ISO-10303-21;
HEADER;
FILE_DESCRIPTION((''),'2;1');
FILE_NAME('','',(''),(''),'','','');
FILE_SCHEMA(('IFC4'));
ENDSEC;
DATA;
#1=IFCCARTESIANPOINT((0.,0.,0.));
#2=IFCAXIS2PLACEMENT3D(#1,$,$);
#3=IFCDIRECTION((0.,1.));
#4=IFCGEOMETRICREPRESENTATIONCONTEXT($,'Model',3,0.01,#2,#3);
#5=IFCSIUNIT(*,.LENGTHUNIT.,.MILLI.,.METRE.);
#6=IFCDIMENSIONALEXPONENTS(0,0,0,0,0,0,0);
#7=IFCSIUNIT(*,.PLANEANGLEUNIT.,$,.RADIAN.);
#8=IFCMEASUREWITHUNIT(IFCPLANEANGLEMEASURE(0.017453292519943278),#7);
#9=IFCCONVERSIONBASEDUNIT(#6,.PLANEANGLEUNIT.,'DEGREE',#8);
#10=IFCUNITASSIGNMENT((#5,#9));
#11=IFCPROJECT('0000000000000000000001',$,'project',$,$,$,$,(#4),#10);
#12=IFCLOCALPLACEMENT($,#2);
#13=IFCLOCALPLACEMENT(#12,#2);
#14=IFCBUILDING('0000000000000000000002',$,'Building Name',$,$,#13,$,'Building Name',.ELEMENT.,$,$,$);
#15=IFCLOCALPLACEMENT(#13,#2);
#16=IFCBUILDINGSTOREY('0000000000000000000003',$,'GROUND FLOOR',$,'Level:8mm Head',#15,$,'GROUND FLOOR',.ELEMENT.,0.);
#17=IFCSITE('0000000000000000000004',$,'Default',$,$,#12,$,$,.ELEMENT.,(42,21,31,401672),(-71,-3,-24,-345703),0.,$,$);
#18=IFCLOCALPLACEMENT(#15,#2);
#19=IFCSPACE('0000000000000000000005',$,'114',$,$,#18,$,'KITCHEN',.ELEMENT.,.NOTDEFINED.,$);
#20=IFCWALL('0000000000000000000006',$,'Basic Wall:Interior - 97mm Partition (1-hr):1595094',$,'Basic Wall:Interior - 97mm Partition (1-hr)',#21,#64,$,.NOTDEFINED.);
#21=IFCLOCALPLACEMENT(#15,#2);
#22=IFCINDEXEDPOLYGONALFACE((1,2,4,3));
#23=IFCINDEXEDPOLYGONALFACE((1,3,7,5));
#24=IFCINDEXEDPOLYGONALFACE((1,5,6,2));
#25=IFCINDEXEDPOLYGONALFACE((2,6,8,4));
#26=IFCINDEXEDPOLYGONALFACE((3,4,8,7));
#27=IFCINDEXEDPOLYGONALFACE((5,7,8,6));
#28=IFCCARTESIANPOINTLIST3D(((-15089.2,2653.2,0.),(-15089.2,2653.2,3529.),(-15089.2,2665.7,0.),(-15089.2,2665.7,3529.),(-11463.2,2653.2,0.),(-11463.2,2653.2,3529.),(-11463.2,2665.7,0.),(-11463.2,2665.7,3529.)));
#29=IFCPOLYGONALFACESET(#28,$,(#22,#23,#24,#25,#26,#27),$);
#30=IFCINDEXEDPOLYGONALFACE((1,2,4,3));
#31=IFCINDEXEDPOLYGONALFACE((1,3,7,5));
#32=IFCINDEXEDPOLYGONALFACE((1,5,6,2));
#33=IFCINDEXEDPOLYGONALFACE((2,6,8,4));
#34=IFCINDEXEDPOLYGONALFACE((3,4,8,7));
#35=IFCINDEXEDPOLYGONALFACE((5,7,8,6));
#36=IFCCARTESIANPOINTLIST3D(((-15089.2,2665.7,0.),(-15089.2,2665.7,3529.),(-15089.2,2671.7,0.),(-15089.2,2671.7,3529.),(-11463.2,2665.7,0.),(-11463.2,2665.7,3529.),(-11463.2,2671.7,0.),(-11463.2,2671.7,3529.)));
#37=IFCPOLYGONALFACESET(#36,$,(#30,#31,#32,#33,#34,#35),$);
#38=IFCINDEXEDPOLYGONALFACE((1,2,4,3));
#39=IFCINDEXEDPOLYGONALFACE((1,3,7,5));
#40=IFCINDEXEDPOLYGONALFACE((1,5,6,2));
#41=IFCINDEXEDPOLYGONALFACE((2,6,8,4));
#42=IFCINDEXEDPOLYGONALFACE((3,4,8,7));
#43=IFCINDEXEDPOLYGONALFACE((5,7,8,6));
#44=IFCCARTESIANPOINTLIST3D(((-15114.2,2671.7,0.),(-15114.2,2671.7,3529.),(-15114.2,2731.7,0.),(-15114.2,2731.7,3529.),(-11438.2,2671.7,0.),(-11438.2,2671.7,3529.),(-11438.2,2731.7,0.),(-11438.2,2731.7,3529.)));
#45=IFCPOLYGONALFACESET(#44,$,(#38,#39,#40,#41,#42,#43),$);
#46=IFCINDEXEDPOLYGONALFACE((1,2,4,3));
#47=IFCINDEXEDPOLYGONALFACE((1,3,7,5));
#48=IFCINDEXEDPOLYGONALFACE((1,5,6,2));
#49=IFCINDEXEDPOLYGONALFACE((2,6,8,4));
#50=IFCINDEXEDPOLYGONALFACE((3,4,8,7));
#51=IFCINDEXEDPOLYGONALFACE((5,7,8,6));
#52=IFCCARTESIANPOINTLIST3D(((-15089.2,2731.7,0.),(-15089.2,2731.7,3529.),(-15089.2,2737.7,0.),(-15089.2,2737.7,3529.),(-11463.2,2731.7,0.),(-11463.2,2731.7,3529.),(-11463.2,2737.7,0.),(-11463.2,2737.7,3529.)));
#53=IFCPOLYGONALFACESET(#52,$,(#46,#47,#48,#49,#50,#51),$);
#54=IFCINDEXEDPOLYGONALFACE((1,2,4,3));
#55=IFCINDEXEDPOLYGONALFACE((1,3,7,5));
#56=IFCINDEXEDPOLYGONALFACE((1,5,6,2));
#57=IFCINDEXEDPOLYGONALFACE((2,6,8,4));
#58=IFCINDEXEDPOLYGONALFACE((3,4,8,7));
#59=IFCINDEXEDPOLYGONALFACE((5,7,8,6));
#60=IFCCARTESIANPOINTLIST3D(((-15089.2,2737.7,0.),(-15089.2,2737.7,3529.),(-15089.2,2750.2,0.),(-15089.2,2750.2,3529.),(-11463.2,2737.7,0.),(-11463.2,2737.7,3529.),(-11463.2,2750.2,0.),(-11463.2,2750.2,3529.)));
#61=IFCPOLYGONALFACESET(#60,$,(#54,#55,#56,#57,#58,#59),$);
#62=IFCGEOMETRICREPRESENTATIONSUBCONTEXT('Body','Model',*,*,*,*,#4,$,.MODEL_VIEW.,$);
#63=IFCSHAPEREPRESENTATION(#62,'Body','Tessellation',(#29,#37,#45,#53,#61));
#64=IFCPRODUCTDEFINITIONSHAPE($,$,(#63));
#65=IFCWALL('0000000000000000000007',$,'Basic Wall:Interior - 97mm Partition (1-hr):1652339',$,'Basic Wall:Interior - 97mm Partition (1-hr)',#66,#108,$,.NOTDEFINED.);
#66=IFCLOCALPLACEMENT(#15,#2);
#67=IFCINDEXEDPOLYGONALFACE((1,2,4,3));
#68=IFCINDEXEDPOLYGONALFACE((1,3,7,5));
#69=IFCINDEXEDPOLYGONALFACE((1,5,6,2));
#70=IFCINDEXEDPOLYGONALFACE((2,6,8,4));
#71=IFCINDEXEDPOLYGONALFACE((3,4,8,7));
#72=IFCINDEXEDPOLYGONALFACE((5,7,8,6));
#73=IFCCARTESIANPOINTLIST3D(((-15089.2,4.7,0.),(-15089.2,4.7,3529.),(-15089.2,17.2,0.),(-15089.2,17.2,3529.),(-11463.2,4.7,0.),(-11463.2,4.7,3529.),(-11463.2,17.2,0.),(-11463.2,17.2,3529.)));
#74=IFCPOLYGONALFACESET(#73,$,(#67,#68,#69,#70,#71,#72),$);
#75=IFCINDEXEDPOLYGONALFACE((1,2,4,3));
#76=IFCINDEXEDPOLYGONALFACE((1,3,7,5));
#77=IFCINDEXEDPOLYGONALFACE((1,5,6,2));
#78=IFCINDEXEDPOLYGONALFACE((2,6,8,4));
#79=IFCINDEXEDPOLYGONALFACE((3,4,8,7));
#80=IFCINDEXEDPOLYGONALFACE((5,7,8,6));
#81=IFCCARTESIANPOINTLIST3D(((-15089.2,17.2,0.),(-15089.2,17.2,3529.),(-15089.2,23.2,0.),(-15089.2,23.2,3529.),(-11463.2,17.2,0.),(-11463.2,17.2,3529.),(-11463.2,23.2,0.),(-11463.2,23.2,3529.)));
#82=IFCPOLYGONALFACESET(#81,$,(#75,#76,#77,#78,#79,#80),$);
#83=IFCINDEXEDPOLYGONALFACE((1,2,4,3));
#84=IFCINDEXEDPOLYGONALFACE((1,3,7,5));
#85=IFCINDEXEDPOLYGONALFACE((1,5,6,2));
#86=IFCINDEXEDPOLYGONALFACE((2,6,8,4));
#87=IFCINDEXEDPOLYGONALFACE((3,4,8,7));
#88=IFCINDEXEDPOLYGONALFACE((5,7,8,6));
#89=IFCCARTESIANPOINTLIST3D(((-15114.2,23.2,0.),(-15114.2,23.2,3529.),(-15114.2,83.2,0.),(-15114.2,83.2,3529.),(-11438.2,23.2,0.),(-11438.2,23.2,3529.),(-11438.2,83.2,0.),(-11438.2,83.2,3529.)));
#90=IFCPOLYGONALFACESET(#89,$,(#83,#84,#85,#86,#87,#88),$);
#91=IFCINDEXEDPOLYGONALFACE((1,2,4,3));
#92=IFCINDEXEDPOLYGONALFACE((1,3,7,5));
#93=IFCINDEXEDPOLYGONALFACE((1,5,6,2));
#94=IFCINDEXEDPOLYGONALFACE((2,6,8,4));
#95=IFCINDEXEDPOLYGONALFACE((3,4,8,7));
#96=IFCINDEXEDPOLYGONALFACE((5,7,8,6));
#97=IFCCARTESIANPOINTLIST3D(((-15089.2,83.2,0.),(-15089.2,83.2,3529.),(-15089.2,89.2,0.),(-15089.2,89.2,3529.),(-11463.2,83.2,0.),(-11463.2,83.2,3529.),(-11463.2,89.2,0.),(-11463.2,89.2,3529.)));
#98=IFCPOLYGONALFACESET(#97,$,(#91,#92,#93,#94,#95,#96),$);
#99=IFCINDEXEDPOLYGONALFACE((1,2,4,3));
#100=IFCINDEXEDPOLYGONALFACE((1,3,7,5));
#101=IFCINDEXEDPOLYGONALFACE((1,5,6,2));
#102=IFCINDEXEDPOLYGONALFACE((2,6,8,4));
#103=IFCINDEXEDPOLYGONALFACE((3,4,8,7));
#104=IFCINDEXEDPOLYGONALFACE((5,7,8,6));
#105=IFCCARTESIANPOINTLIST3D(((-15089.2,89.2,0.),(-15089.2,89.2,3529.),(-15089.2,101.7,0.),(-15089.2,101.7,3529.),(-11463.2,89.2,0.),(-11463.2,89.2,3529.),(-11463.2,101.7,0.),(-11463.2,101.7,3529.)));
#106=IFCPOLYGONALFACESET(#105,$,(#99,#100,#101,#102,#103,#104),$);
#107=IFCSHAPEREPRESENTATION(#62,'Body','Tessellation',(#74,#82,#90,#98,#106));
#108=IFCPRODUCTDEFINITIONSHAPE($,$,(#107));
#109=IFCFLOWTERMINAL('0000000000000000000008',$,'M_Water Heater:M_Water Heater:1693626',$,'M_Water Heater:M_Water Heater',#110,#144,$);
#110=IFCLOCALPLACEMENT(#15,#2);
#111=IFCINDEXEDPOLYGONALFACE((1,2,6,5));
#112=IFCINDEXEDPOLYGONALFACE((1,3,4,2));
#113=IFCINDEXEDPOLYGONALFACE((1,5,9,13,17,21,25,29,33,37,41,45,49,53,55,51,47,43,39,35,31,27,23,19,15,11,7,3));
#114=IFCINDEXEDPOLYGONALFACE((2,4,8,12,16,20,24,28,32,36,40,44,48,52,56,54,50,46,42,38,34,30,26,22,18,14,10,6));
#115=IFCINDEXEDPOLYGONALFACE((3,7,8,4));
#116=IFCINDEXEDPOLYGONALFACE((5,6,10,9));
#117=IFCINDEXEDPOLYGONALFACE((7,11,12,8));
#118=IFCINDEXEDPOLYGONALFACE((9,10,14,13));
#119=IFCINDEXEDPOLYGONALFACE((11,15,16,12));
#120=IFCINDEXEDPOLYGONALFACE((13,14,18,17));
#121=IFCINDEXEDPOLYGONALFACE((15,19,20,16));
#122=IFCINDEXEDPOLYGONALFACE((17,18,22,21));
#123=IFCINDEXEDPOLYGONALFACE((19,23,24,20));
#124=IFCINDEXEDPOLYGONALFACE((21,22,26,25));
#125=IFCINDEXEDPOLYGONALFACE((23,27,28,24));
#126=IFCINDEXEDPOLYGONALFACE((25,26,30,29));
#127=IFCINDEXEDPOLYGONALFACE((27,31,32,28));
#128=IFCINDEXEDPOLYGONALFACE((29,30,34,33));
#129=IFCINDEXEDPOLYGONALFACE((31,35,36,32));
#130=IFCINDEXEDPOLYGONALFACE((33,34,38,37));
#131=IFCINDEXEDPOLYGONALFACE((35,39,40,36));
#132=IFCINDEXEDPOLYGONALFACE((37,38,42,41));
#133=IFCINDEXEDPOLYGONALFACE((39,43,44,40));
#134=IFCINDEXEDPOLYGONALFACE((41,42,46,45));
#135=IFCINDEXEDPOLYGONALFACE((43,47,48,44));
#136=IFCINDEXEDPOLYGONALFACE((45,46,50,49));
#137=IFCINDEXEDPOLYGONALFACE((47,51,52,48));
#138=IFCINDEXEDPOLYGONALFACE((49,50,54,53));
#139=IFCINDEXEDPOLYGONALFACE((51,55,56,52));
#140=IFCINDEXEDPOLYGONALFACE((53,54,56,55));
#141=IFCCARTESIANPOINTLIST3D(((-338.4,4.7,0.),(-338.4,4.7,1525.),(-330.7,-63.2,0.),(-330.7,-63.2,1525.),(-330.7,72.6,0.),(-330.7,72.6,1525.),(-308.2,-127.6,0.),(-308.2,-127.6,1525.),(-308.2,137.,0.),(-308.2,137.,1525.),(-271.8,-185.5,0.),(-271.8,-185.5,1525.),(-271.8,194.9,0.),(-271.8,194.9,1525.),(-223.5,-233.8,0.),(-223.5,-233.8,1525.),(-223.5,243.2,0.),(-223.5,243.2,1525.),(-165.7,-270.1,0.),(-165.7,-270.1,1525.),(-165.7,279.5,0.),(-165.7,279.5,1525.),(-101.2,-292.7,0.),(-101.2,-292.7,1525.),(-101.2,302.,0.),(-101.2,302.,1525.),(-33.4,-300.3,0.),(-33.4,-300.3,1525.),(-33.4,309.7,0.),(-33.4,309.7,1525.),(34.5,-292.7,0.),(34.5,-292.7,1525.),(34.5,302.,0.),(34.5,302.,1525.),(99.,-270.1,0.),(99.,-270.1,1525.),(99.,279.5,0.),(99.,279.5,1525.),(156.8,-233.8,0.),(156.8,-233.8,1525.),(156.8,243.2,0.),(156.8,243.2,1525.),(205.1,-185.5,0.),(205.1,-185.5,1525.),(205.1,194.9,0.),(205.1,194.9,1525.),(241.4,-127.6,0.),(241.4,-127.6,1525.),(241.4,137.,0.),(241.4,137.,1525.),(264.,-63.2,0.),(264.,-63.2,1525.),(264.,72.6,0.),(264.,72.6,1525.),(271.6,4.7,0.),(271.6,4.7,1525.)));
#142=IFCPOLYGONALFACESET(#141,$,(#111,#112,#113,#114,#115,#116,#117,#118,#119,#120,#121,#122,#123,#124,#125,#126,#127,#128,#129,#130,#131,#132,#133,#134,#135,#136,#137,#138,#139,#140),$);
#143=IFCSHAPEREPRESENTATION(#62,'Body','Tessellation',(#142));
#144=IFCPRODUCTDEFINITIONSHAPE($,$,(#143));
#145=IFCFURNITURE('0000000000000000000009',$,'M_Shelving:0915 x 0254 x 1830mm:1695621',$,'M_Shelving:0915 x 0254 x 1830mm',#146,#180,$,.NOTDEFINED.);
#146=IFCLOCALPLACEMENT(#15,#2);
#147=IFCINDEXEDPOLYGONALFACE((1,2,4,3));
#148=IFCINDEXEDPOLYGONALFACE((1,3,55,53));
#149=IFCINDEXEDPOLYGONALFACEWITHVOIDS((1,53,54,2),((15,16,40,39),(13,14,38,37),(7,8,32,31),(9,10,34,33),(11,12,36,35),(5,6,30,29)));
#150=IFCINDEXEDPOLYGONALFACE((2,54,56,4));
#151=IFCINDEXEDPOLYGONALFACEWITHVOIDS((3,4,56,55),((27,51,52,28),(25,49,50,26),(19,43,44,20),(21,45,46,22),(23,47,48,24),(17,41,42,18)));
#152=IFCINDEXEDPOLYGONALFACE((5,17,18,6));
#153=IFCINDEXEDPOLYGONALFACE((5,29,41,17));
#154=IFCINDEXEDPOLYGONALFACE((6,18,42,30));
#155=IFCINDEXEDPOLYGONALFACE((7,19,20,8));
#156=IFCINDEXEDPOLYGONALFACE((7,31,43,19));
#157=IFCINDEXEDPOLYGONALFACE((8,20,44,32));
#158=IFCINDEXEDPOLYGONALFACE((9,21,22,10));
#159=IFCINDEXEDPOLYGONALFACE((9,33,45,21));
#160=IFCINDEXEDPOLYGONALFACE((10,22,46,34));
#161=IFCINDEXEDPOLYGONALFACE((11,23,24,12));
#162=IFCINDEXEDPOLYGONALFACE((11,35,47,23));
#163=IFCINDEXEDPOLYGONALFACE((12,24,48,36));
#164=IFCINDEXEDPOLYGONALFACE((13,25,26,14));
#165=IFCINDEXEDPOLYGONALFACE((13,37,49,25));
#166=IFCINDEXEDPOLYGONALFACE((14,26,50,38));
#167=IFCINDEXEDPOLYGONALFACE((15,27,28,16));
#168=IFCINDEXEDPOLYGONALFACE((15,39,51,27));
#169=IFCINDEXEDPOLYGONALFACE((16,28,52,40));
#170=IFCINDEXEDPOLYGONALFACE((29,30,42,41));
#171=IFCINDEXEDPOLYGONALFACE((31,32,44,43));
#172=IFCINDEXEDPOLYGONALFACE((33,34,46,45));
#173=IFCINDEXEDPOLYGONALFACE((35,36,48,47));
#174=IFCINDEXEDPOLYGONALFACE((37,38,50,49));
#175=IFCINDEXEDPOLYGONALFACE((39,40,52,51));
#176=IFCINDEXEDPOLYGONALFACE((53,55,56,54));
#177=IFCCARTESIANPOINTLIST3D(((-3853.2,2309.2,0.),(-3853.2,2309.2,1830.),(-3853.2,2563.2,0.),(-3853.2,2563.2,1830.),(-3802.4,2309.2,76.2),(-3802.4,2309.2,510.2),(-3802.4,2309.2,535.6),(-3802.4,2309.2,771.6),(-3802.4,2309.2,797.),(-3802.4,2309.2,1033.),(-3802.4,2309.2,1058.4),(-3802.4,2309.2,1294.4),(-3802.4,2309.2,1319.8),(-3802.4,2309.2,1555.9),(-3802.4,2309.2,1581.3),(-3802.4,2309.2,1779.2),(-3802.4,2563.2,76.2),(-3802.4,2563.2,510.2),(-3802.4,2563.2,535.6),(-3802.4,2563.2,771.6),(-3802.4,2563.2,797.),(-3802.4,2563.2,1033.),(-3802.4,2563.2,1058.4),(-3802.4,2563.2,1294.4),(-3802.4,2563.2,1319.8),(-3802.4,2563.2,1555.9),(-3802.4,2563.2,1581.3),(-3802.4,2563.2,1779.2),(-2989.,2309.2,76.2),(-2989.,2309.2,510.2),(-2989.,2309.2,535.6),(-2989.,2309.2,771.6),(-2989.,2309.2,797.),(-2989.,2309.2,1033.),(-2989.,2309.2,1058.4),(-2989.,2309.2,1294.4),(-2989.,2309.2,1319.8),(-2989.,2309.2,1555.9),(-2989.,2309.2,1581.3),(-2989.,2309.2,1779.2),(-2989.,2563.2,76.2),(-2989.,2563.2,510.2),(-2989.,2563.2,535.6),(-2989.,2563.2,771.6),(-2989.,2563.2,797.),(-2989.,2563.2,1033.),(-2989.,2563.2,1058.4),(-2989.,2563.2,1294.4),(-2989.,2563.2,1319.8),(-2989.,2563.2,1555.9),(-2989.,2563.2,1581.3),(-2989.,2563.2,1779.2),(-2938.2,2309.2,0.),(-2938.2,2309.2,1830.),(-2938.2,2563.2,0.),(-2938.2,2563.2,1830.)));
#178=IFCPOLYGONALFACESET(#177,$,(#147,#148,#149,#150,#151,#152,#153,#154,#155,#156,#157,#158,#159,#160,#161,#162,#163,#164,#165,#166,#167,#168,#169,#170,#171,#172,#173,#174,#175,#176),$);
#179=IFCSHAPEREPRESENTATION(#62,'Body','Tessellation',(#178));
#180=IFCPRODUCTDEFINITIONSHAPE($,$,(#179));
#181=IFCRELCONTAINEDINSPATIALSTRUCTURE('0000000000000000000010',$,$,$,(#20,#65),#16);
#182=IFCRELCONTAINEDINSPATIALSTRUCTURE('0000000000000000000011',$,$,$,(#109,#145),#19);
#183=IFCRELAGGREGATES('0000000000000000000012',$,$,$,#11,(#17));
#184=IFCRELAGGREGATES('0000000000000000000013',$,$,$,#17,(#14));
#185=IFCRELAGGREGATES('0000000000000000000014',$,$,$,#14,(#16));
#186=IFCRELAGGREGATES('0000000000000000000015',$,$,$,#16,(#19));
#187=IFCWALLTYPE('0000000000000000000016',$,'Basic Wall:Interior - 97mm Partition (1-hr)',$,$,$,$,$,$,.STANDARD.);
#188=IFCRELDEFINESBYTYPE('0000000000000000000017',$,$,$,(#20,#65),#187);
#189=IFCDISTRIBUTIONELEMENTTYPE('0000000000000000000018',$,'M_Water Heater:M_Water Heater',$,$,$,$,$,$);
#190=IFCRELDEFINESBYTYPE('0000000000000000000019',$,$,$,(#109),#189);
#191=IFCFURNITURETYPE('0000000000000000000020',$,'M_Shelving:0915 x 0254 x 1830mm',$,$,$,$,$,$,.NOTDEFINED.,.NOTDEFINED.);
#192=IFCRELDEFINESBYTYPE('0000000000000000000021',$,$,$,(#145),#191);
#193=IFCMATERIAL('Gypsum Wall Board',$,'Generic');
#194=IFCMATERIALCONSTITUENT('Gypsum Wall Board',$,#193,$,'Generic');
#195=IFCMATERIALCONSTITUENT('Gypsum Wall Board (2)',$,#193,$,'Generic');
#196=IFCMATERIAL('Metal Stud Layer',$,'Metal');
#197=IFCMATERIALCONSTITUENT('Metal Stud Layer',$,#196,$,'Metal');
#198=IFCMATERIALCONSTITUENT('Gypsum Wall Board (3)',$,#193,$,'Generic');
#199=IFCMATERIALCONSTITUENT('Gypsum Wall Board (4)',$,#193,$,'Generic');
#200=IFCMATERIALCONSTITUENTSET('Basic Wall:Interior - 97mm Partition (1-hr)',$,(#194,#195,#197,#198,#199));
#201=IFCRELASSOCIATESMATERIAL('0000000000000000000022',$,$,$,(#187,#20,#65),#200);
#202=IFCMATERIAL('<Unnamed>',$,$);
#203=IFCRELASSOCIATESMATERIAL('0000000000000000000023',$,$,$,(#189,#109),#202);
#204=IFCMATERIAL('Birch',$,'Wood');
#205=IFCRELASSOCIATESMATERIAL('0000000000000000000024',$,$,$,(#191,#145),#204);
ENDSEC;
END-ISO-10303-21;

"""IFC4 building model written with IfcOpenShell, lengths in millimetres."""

from ifc_helpers import new_model, entity, si_unit, converted_unit, direction, frame, origin, place, context, subcontext, project, spatial, arc, indexed_curve, outline, extrude, source, transform, mapped, material, constituent, constituent_set, type_object, type_shapes, element, save


model = new_model("IFC4")

# Units and contexts
model_context = context("Model", 3, precision=0.01, world=origin(), true_north=direction((0.0, 1.0)))
body_context = subcontext(model_context, "Body", "Model", "MODEL_VIEW")
ifc_project = project(units=[si_unit("LENGTHUNIT", "METRE", prefix="MILLI"), converted_unit("PLANEANGLEUNIT", "DEGREE", entity("IfcPlaneAngleMeasure", 0.017453292519943278), si_unit("PLANEANGLEUNIT", "RADIAN"), dimensions=[0, 0, 0, 0, 0, 0, 0])], contexts=[model_context])

# Site, building, storey
site_placement = place(None, origin())
site = spatial("IfcSite", under=ifc_project, at=site_placement, Name="Default", CompositionType="ELEMENT", RefLatitude=(42, 21, 31, 401672), RefLongitude=(-71, -3, -24, -345703), RefElevation=0.0)
building_placement = place(site_placement, origin())
building = spatial("IfcBuilding", under=site, at=building_placement, Name="Building Name", LongName="Building Name", CompositionType="ELEMENT")
storey_placement = place(building_placement, origin())
storey = spatial("IfcBuildingStorey", under=building, at=storey_placement, Name="GROUND FLOOR", ObjectType="Level:8mm Head", LongName="GROUND FLOOR", CompositionType="ELEMENT", Elevation=0.0)

# Walls
ifc_material_1 = material(Name="Gypsum Wall Board", Category="Generic")
ifc_constituent_1 = constituent(ifc_material_1, Name="Gypsum Wall Board", Category="Generic")
ifc_constituent_2 = constituent(ifc_material_1, Name="Gypsum Wall Board (2)", Category="Generic")
ifc_material_2 = material(Name="Metal Stud Layer", Category="Metal")
ifc_constituent_3 = constituent(ifc_material_2, Name="Metal Stud Layer", Category="Metal")
ifc_constituent_4 = constituent(ifc_material_1, Name="Gypsum Wall Board (3)", Category="Generic")
ifc_constituent_5 = constituent(ifc_material_1, Name="Gypsum Wall Board (4)", Category="Generic")
ifc_constituent_set_1 = constituent_set(constituents=[ifc_constituent_1, ifc_constituent_2, ifc_constituent_3, ifc_constituent_4, ifc_constituent_5], Name="Basic Wall:Interior - 97mm Partition (1-hr)")
wall_type_1 = type_object("IfcWallType", Name="Basic Wall:Interior - 97mm Partition (1-hr)", PredefinedType="STANDARD", material=ifc_constituent_set_1)
wall_1_placement = place(storey_placement, frame((-15089.2, 2701.7, 0.0)))
element("IfcWall", 1, at=wall_1_placement, inside=storey, type_object=wall_type_1, material=ifc_constituent_set_1, Name="Basic Wall:Interior - 97mm Partition (1-hr):1595094", ObjectType="Basic Wall:Interior - 97mm Partition (1-hr)", PredefinedType="NOTDEFINED", context=body_context, shape_type="SweptSolid", body=[
    extrude(outline(indexed_curve([(-6.3, -1813.0), (6.2, -1813.0), (6.3, 1813.0), (-6.2, 1813.0), (-6.3, -1813.0)], self_intersect=False)), frame((1813.0, -42.3, 0.0), z_axis=(0.0, 0.0, 1.0), x_axis=(0.0, 1.0, 0.0)), (0.0, 0.0, 1.0), 3529.0),
    extrude(outline(indexed_curve([(-1813.0, -3.0), (1813.0, -3.0), (1813.0, 3.0), (-1813.0, 3.0), (-1813.0, -3.0)], self_intersect=False)), frame((1813.0, -33.0, 0.0)), (0.0, 0.0, 1.0), 3529.0),
    extrude(outline(indexed_curve([(-1838.0, -30.0), (1838.0, -30.0), (1838.0, 30.0), (-1838.0, 30.0), (-1838.0, -30.0)], self_intersect=False)), frame((1813.0, 0.0, 0.0)), (0.0, 0.0, 1.0), 3529.0),
    extrude(outline(indexed_curve([(-1813.0, -3.0), (1813.0, -3.0), (1813.0, 3.0), (-1813.0, 3.0), (-1813.0, -3.0)], self_intersect=False)), frame((1813.0, 33.0, 0.0)), (0.0, 0.0, 1.0), 3529.0),
    extrude(outline(indexed_curve([(-6.3, -1813.0), (6.2, -1813.0), (6.3, 1813.0), (-6.2, 1813.0), (-6.3, -1813.0)], self_intersect=False)), frame((1813.0, 42.2, 0.0), z_axis=(0.0, 0.0, 1.0), x_axis=(0.0, -1.0, 0.0)), (0.0, 0.0, 1.0), 3529.0),
])
wall_2_placement = place(storey_placement, frame((-15089.2, 53.2, 0.0)))
element("IfcWall", 2, at=wall_2_placement, inside=storey, type_object=wall_type_1, material=ifc_constituent_set_1, Name="Basic Wall:Interior - 97mm Partition (1-hr):1652339", ObjectType="Basic Wall:Interior - 97mm Partition (1-hr)", PredefinedType="NOTDEFINED", context=body_context, shape_type="SweptSolid", body=[
    extrude(outline(indexed_curve([(-6.3, -1813.0), (6.2, -1813.0), (6.3, 1813.0), (-6.2, 1813.0), (-6.3, -1813.0)], self_intersect=False)), frame((1813.0, -42.3, 0.0), z_axis=(0.0, 0.0, 1.0), x_axis=(0.0, 1.0, 0.0)), (0.0, 0.0, 1.0), 3529.0),
    extrude(outline(indexed_curve([(-1813.0, -3.0), (1813.0, -3.0), (1813.0, 3.0), (-1813.0, 3.0), (-1813.0, -3.0)], self_intersect=False)), frame((1813.0, -33.0, 0.0)), (0.0, 0.0, 1.0), 3529.0),
    extrude(outline(indexed_curve([(-1838.0, -30.0), (1838.0, -30.0), (1838.0, 30.0), (-1838.0, 30.0), (-1838.0, -30.0)], self_intersect=False)), frame((1813.0, 0.0, 0.0)), (0.0, 0.0, 1.0), 3529.0),
    extrude(outline(indexed_curve([(-1813.0, -3.0), (1813.0, -3.0), (1813.0, 3.0), (-1813.0, 3.0), (-1813.0, -3.0)], self_intersect=False)), frame((1813.0, 33.0, 0.0)), (0.0, 0.0, 1.0), 3529.0),
    extrude(outline(indexed_curve([(-6.3, -1813.0), (6.2, -1813.0), (6.3, 1813.0), (-6.2, 1813.0), (-6.3, -1813.0)], self_intersect=False)), frame((1813.0, 42.3, 0.0), z_axis=(0.0, 0.0, 1.0), x_axis=(0.0, -1.0, 0.0)), (0.0, 0.0, 1.0), 3529.0),
])

# Shared definitions
space_1_placement = place(storey_placement, origin())
space_1 = spatial("IfcSpace", under=storey, at=space_1_placement, Name="114", LongName="KITCHEN", CompositionType="ELEMENT", PredefinedType="NOTDEFINED")

# Flow terminal
ifc_material_3 = material(Name="<Unnamed>")
distribution_element_type = type_object("IfcDistributionElementType", Name="M_Water Heater:M_Water Heater", material=ifc_material_3)
shared_shape_1 = source(origin(), body_context, "Body", "SweptSolid", [
    extrude(outline(indexed_curve([(-305.0, 0.0), (0.0, -305.0), (305.0, 0.0), (0.0, 305.0)], segments=[arc(1, 2, 3), arc(3, 4, 1)], self_intersect=False)), origin(), (0.0, 0.0, 1.0), 1525.0),
])
type_shapes(distribution_element_type, [shared_shape_1])
flow_terminal_placement = place(space_1_placement, frame((-33.4, 4.7, 0.0)))
element("IfcFlowTerminal", 3, at=flow_terminal_placement, inside=space_1, type_object=distribution_element_type, material=ifc_material_3, Name="M_Water Heater:M_Water Heater:1693626", ObjectType="M_Water Heater:M_Water Heater", context=body_context, shape_type="MappedRepresentation", body=[
    mapped(shared_shape_1, transform((0.0, 0.0, 0.0), scale=1.0)),
])

# Furniture
ifc_material_4 = material(Name="Birch", Category="Wood")
furniture_type_1 = type_object("IfcFurnitureType", Name="M_Shelving:0915 x 0254 x 1830mm", AssemblyPlace="NOTDEFINED", PredefinedType="NOTDEFINED", material=ifc_material_4)
shared_shape_2 = source(origin(), body_context, "Body", "SweptSolid", [
    extrude(outline(indexed_curve([(-457.5, -915.0), (457.5, -915.0), (457.5, 915.0), (-457.5, 915.0), (-457.5, -915.0)], self_intersect=False), holes=[indexed_curve([(-406.7, 864.2), (406.7, 864.2), (406.7, 666.3), (-406.7, 666.3), (-406.7, 864.2)], self_intersect=False), indexed_curve([(-406.7, -838.8), (-406.7, -404.8), (406.7, -404.8), (406.7, -838.8), (-406.7, -838.8)], self_intersect=False), indexed_curve([(406.7, 143.4), (-406.7, 143.4), (-406.7, 379.4), (406.7, 379.4), (406.7, 143.4)], self_intersect=False), indexed_curve([(-406.7, 640.9), (406.7, 640.9), (406.7, 404.8), (-406.7, 404.8), (-406.7, 640.9)], self_intersect=False), indexed_curve([(-406.7, 118.0), (406.7, 118.0), (406.7, -118.0), (-406.7, -118.0), (-406.7, 118.0)], self_intersect=False), indexed_curve([(-406.7, -143.4), (406.7, -143.4), (406.7, -379.4), (-406.7, -379.4), (-406.7, -143.4)], self_intersect=False)]), frame((0.0, -431.8, 915.0), z_axis=(0.0, 1.0, 0.0), x_axis=(-1.0, 0.0, 0.0)), (0.0, 0.0, 1.0), 254.0),
])
type_shapes(furniture_type_1, [shared_shape_2])
for number, where, name in (
    (4, (-3395.7, 2741.0, 0.0), "M_Shelving:0915 x 0254 x 1830mm:1695621"),
):
    element("IfcFurniture", number, at=place(space_1_placement, frame(where)), inside=space_1, type_object=furniture_type_1, material=ifc_material_4, Name=name, ObjectType="M_Shelving:0915 x 0254 x 1830mm", PredefinedType="NOTDEFINED", context=body_context, shape_type="MappedRepresentation", body=[
        mapped(shared_shape_2, transform((0.0, 0.0, 0.0), scale=1.0)),
    ])

save(model, "model.ifc")
